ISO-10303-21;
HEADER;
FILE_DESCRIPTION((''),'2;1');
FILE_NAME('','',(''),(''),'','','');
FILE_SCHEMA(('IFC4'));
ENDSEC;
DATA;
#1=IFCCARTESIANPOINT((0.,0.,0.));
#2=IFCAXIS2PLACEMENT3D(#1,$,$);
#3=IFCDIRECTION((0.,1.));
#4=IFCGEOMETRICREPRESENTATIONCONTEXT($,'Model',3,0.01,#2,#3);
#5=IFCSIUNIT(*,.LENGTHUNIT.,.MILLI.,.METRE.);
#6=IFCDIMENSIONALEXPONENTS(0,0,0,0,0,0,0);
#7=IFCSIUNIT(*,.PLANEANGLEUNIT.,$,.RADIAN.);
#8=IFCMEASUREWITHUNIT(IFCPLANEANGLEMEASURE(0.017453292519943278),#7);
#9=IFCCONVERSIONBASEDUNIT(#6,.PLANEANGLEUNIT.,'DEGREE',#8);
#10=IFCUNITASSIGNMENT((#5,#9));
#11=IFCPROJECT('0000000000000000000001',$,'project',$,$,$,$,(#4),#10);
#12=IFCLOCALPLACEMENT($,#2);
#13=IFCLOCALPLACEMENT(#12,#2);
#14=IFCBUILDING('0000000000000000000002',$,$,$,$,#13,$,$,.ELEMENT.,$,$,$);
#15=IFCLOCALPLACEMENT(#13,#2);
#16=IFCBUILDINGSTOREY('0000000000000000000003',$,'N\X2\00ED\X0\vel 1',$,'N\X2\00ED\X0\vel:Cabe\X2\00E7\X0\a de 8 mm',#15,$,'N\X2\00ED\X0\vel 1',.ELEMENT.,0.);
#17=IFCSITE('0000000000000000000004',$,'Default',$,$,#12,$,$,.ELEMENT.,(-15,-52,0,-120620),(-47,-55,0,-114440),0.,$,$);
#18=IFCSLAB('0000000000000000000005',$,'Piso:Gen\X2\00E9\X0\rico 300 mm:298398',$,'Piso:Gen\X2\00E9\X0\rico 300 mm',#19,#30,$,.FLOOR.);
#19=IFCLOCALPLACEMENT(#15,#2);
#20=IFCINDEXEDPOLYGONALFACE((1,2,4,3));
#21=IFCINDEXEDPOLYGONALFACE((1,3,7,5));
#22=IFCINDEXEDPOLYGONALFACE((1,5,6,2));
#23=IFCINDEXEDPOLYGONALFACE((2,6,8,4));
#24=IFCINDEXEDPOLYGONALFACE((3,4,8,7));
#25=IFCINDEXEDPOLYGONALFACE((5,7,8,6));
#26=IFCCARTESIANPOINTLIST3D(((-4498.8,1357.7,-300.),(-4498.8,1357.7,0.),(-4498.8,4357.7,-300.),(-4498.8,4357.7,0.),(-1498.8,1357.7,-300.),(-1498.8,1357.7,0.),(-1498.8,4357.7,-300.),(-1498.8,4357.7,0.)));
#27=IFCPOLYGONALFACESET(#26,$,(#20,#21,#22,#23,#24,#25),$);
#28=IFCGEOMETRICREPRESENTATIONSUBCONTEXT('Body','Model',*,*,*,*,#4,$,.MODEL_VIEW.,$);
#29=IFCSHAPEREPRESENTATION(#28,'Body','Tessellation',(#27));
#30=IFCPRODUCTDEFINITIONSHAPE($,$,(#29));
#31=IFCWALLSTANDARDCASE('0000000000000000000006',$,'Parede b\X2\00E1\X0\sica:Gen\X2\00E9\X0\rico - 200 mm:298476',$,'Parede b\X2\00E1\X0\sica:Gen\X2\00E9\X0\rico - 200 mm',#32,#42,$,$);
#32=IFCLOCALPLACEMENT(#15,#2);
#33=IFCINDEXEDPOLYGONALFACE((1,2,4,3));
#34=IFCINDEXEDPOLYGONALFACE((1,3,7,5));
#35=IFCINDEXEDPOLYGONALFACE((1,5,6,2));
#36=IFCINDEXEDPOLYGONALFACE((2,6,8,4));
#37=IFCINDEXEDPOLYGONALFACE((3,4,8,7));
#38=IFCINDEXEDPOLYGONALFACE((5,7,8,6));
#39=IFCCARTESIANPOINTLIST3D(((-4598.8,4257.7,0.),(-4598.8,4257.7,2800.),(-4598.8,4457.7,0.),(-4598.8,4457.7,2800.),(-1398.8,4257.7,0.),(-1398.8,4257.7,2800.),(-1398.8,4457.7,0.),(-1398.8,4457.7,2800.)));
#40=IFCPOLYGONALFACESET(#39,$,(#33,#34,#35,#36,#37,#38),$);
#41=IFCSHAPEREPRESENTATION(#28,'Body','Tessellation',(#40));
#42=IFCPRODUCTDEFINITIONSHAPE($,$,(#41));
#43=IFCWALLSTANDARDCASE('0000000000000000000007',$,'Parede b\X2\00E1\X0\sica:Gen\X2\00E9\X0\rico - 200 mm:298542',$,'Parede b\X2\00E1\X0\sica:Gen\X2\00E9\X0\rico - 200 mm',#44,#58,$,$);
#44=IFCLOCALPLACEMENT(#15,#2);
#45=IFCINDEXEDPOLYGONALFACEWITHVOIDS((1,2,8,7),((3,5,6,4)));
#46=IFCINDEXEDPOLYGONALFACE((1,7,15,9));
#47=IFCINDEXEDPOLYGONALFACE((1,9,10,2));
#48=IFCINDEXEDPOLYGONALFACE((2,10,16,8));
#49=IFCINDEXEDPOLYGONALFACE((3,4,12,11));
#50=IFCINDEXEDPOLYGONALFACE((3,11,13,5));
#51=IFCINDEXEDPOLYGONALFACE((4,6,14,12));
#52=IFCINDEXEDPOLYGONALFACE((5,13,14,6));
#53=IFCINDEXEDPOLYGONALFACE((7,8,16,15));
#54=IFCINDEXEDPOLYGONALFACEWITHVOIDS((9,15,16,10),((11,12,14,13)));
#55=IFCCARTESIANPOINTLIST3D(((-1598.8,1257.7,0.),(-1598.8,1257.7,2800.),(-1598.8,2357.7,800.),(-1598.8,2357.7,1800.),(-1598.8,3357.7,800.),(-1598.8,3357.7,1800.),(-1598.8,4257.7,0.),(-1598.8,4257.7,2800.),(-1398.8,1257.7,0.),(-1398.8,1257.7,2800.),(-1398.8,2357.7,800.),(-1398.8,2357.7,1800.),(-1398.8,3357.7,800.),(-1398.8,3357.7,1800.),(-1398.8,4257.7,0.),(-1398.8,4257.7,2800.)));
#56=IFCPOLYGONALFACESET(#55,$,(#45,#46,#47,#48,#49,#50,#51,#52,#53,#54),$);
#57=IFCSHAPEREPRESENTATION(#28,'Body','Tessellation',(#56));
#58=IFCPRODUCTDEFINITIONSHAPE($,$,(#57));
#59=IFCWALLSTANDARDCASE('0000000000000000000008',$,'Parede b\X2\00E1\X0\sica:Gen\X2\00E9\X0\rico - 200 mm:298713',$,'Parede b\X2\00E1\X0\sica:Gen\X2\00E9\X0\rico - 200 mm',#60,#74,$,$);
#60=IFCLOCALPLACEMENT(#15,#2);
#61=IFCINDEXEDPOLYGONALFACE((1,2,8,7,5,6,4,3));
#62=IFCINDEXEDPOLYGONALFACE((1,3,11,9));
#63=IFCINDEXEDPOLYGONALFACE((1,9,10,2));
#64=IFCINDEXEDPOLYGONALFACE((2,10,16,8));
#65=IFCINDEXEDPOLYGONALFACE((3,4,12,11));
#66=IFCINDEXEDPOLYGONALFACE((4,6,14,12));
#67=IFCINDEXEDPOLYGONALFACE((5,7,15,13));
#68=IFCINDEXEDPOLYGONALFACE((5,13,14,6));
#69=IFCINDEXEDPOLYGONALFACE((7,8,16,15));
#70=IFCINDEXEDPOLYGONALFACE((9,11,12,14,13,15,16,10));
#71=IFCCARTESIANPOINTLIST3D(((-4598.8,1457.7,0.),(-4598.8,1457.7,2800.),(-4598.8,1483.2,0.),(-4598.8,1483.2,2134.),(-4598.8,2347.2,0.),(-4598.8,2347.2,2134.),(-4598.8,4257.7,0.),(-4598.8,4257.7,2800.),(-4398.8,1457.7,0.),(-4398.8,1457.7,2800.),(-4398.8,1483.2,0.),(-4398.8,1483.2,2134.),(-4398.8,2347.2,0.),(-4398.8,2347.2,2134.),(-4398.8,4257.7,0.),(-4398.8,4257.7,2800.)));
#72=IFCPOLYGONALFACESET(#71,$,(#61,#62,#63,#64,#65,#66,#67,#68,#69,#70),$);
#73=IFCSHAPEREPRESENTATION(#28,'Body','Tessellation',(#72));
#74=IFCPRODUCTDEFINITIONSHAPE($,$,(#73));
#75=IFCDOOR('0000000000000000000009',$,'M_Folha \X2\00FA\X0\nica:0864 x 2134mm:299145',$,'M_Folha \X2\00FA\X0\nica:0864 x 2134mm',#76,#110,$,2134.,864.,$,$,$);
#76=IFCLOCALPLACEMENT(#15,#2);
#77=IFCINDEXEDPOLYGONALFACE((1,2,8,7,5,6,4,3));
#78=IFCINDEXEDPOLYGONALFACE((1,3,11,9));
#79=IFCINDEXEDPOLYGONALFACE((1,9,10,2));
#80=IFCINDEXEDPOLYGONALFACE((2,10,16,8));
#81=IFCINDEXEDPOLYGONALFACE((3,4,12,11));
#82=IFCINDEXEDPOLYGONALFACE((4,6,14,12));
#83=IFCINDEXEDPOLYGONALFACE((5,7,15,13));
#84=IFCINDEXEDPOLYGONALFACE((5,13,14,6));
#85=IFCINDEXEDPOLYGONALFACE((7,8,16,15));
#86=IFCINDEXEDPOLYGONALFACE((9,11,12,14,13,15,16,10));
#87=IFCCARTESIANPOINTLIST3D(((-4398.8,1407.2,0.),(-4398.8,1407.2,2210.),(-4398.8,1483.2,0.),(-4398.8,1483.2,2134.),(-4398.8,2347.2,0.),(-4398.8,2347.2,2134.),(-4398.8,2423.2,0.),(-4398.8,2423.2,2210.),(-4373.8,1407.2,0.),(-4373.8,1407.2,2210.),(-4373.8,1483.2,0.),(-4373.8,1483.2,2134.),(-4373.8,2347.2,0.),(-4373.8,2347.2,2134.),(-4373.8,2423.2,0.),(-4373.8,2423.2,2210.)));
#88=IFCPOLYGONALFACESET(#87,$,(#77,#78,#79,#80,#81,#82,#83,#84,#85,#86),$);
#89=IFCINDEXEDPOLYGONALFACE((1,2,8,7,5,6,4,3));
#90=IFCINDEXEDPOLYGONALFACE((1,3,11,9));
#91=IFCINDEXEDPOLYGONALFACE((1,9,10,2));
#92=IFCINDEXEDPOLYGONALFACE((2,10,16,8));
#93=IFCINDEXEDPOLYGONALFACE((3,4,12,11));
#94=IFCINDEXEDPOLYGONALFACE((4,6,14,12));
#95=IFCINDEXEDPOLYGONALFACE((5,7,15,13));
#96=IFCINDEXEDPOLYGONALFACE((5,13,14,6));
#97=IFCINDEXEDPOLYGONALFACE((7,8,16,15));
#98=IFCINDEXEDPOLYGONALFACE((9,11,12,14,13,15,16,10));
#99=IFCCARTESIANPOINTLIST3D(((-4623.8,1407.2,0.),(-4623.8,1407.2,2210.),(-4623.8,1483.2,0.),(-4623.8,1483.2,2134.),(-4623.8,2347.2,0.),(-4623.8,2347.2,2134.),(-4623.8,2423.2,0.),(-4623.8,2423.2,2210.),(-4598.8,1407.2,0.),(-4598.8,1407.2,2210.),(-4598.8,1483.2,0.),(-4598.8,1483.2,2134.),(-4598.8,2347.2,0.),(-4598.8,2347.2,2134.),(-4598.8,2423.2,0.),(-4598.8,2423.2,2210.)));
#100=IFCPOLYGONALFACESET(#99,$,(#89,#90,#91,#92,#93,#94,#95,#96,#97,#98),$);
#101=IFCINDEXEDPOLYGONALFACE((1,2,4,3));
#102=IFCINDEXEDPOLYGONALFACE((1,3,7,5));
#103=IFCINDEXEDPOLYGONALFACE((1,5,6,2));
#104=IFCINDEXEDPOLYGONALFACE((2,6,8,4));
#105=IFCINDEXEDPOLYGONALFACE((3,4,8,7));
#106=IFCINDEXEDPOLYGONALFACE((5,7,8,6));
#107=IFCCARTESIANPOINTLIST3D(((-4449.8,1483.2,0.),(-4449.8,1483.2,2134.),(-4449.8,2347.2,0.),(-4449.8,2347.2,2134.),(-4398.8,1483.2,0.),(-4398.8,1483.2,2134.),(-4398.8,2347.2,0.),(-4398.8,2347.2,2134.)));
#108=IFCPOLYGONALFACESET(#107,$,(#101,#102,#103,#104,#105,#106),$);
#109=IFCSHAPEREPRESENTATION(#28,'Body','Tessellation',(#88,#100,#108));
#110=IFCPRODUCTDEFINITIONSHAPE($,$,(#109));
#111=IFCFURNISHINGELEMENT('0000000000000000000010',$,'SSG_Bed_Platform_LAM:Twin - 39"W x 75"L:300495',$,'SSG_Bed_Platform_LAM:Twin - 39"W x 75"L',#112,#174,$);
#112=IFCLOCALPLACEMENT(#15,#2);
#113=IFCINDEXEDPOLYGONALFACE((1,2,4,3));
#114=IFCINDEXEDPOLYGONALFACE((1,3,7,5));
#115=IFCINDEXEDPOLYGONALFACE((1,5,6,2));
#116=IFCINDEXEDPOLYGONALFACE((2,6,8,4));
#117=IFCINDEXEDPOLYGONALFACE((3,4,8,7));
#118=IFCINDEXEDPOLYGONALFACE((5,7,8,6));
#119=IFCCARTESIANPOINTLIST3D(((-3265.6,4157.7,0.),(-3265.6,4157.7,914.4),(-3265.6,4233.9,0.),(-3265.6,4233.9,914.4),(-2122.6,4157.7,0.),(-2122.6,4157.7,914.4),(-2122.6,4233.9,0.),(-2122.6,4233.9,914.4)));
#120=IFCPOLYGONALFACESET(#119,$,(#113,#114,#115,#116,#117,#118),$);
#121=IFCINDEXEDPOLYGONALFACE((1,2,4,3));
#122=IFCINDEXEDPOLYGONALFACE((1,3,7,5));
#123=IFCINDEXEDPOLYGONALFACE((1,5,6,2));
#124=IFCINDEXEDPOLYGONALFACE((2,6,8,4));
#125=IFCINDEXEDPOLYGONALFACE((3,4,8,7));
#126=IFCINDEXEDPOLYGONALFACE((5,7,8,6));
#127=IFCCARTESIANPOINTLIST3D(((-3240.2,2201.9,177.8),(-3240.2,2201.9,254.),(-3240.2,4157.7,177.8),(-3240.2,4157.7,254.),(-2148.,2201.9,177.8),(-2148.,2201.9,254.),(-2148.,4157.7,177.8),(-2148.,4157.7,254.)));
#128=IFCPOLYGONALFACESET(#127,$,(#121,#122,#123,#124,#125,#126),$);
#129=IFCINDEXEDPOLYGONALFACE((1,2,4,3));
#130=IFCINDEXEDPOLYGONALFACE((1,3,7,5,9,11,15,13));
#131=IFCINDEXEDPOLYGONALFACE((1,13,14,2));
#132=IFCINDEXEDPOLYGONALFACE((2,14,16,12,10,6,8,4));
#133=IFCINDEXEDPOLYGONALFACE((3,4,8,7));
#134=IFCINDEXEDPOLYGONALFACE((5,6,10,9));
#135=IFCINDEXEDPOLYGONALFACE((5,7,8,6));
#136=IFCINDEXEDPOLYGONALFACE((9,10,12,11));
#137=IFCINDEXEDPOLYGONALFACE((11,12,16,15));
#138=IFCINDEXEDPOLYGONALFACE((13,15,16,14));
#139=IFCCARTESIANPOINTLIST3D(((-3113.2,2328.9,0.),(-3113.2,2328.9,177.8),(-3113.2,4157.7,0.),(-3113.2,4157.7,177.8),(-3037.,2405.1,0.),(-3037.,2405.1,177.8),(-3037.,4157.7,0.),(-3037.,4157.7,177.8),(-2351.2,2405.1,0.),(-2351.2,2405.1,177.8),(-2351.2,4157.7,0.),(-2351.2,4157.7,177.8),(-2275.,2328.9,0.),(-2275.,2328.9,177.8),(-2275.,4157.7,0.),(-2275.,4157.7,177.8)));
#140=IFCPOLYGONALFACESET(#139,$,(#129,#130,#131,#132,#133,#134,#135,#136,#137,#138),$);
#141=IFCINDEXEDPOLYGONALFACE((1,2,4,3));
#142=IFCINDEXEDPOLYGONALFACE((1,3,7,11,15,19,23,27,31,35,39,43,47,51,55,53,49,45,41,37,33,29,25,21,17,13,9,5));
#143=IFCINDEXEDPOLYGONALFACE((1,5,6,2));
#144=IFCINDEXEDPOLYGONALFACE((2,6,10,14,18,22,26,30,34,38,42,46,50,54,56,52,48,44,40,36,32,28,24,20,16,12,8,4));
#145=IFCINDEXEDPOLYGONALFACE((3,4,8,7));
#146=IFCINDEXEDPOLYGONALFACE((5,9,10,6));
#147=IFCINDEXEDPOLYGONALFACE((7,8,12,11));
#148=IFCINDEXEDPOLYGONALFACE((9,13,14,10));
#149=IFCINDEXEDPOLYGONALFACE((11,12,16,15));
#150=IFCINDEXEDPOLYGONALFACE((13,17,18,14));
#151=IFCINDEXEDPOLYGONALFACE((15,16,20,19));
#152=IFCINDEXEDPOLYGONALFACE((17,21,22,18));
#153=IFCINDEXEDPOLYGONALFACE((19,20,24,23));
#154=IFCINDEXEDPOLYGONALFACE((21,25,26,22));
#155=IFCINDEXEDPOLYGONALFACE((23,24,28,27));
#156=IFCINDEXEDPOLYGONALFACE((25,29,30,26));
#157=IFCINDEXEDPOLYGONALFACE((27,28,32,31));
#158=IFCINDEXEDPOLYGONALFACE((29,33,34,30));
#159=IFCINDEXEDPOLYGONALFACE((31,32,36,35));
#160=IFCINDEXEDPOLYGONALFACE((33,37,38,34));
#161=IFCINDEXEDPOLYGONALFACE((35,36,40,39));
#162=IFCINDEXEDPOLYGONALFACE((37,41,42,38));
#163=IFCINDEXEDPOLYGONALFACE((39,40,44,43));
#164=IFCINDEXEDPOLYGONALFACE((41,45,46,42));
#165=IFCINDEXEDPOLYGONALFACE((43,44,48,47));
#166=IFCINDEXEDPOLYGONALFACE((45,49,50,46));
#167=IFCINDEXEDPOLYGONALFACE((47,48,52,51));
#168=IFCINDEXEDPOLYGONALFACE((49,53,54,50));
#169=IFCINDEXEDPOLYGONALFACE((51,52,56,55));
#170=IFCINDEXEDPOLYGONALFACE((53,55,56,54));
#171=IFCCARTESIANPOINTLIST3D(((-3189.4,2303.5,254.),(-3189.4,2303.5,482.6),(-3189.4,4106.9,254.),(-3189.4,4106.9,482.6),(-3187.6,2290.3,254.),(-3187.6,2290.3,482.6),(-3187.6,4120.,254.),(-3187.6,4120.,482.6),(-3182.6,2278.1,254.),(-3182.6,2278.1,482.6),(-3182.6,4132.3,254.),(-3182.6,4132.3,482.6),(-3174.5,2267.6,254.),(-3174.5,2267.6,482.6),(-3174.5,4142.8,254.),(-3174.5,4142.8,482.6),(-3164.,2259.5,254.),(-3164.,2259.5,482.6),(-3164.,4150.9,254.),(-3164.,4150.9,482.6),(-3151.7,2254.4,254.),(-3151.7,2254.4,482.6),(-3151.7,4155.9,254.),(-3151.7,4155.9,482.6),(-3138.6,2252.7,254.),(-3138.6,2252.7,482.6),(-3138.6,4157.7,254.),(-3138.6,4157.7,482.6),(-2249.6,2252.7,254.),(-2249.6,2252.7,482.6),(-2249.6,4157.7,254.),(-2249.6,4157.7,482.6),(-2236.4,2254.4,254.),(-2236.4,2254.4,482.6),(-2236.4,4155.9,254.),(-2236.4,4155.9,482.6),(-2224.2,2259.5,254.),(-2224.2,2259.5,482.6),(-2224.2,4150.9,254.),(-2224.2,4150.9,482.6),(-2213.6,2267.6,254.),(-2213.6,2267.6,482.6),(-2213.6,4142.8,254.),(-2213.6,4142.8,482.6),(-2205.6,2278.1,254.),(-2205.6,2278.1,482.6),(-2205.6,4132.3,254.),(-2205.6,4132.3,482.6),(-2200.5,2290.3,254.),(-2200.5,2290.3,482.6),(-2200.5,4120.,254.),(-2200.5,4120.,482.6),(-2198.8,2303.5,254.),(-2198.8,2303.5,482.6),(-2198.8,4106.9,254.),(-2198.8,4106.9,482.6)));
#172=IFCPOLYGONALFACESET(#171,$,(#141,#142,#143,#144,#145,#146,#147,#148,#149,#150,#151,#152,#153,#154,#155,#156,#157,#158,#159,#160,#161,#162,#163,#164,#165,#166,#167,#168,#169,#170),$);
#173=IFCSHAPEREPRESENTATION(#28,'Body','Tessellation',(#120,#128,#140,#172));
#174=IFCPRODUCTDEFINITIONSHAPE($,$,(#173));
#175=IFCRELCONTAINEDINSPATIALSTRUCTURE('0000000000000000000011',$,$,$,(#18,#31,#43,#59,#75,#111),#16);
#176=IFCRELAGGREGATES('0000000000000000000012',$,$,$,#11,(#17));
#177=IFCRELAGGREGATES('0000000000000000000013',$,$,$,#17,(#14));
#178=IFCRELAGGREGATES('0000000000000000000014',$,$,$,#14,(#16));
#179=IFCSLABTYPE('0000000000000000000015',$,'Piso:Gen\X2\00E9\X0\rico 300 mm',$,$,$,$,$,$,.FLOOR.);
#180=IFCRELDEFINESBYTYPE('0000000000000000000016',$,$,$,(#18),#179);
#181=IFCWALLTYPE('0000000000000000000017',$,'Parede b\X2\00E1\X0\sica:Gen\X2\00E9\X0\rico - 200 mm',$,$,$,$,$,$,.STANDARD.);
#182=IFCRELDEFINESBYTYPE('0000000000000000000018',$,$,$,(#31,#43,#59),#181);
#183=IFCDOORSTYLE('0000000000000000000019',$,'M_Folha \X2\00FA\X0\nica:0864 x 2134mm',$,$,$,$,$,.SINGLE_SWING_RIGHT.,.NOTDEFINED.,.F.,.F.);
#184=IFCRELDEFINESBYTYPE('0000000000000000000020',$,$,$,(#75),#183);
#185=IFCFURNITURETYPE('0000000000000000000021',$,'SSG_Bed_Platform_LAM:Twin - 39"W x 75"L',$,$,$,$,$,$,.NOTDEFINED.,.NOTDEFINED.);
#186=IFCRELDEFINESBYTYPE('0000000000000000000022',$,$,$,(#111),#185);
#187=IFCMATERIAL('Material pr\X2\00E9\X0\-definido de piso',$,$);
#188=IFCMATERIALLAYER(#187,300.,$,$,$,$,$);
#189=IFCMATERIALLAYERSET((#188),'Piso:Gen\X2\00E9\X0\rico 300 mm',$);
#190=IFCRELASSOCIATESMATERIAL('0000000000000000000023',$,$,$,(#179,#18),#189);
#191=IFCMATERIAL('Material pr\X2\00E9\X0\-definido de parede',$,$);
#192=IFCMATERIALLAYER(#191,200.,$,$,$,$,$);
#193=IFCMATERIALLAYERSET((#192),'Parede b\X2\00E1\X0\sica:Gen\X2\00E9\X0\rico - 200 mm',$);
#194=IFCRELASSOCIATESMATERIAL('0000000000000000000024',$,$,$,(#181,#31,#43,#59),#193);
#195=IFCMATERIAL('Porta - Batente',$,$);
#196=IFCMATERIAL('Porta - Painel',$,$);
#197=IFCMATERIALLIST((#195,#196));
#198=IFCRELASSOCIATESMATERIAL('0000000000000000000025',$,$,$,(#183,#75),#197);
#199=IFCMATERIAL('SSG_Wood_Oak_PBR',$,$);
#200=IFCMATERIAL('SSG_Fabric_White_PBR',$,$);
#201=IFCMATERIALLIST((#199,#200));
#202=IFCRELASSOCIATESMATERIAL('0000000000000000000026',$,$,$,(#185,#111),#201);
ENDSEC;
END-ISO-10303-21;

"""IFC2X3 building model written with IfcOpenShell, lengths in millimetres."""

from ifc_helpers import new_model, entity, si_unit, converted_unit, direction, frame, frame_2d, origin, origin_2d_with_axis, place, context, subcontext, project, spatial, polyline, circle_curve, parameter, trimmed, segment, composite_curve, rectangle, outline, extrude, source, transform, mapped, material, material_list, layer, layer_set, layer_usage, type_object, type_shapes, element, fill, save


model = new_model("IFC2X3")

# Units and contexts
model_context = context("Model", 3, precision=0.01, world=origin(), true_north=direction((0.0, 1.0)))
body_context = subcontext(model_context, "Body", "Model", "MODEL_VIEW")
ifc_project = project(units=[si_unit("LENGTHUNIT", "METRE", prefix="MILLI"), converted_unit("PLANEANGLEUNIT", "DEGREE", entity("IfcPlaneAngleMeasure", 0.017453292519943278), si_unit("PLANEANGLEUNIT", "RADIAN"), dimensions=[0, 0, 0, 0, 0, 0, 0])], contexts=[model_context])

# Site, building, storey
site_placement = place(None, origin())
site = spatial("IfcSite", under=ifc_project, at=site_placement, Name="Default", CompositionType="ELEMENT", RefLatitude=(-15, -52, 0, -120620), RefLongitude=(-47, -55, 0, -114440), RefElevation=0.0)
building_placement = place(site_placement, origin())
building = spatial("IfcBuilding", under=site, at=building_placement, CompositionType="ELEMENT")
storey_placement = place(building_placement, origin())
storey = spatial("IfcBuildingStorey", under=building, at=storey_placement, Name="Nível 1", ObjectType="Nível:Cabeça de 8 mm", LongName="Nível 1", CompositionType="ELEMENT", Elevation=0.0)

# Slab
ifc_material_1 = material(Name="Material pré-definido de piso")
ifc_layer_1 = layer(ifc_material_1, 300.0)
ifc_layer_set_1 = layer_set([ifc_layer_1], Name="Piso:Genérico 300 mm")
ifc_layer_usage_1 = layer_usage(ifc_layer_set_1, "AXIS3", "POSITIVE", 0.0)
slab_type = type_object("IfcSlabType", Name="Piso:Genérico 300 mm", PredefinedType="FLOOR", material=ifc_layer_set_1)
slab_placement = place(storey_placement, origin())
element("IfcSlab", 1, at=slab_placement, inside=storey, type_object=slab_type, material=ifc_layer_usage_1, Name="Piso:Genérico 300 mm:298398", ObjectType="Piso:Genérico 300 mm", PredefinedType="FLOOR", context=body_context, shape_type="SweptSolid", body=[
    extrude(rectangle(XDim=3000.0, YDim=3000.0, at=origin_2d_with_axis()), frame((-2998.8, 2857.7, 0.0), z_axis=(0.0, 0.0, -1.0), x_axis=(0.0, 1.0, 0.0)), (0.0, 0.0, 1.0), 300.0),
])

# Wall
ifc_material_2 = material(Name="Material pré-definido de parede")
ifc_layer_2 = layer(ifc_material_2, 200.0)
ifc_layer_set_2 = layer_set([ifc_layer_2], Name="Parede básica:Genérico - 200 mm")
ifc_layer_usage_2 = layer_usage(ifc_layer_set_2, "AXIS2", "NEGATIVE", 100.0)
wall_type = type_object("IfcWallType", Name="Parede básica:Genérico - 200 mm", PredefinedType="STANDARD", material=ifc_layer_set_2)
wall_1_placement = place(storey_placement, frame((-4598.8, 4357.7, 0.0)))
element("IfcWallStandardCase", 2, at=wall_1_placement, inside=storey, type_object=wall_type, material=ifc_layer_usage_2, Name="Parede básica:Genérico - 200 mm:298476", ObjectType="Parede básica:Genérico - 200 mm", context=body_context, shape_type="SweptSolid", body=[
    extrude(rectangle(XDim=3200.0, YDim=200.0, at=frame_2d((1600.0, 0.0), x_axis=(-1.0, 0.0))), origin(), (0.0, 0.0, 1.0), 2800.0),
])

# Wall, opening
wall_2_placement = place(storey_placement, frame((-1498.8, 4257.7, 0.0), z_axis=(0.0, 0.0, 1.0), x_axis=(0.0, -1.0, 0.0)))
wall_2 = element("IfcWallStandardCase", 3, at=wall_2_placement, inside=storey, type_object=wall_type, material=ifc_layer_usage_2, Name="Parede básica:Genérico - 200 mm:298542", ObjectType="Parede básica:Genérico - 200 mm", context=body_context, shape_type="SweptSolid", body=[
    extrude(rectangle(XDim=3000.0, YDim=200.0, at=frame_2d((1500.0, 0.0), x_axis=(-1.0, 0.0))), origin(), (0.0, 0.0, 1.0), 2800.0),
])
opening_1_placement = place(wall_2_placement, frame((1900.0, 100.0, 800.0)))
element("IfcOpeningElement", 4, at=opening_1_placement, cuts=wall_2, ObjectType="Opening", context=body_context, shape_type="SweptSolid", body=[
    extrude(rectangle(XDim=1000.0, YDim=1000.0, at=frame_2d((500.0, 500.0), x_axis=(1.0, 0.0))), frame((0.0, 0.0, 0.0), z_axis=(0.0, -1.0, 0.0), x_axis=(0.0, 0.0, 1.0)), (0.0, 0.0, 1.0), 200.0),
])

# Wall, opening, door
wall_3_placement = place(storey_placement, frame((-4498.8, 1457.7, 0.0), z_axis=(0.0, 0.0, 1.0), x_axis=(0.0, 1.0, 0.0)))
wall_3 = element("IfcWallStandardCase", 5, at=wall_3_placement, inside=storey, type_object=wall_type, material=ifc_layer_usage_2, Name="Parede básica:Genérico - 200 mm:298713", ObjectType="Parede básica:Genérico - 200 mm", context=body_context, shape_type="SweptSolid", body=[
    extrude(rectangle(XDim=2800.0, YDim=200.0, at=frame_2d((1400.0, 0.0), x_axis=(-1.0, 0.0))), origin(), (0.0, 0.0, 1.0), 2800.0),
])
opening_2_placement = place(wall_3_placement, frame((889.5, 100.0, 0.0)))
opening_2 = element("IfcOpeningElement", 6, at=opening_2_placement, cuts=wall_3, ObjectType="Opening", context=body_context, shape_type="SweptSolid", body=[
    extrude(rectangle(XDim=864.0, YDim=2134.0, at=frame_2d((1067.0, 432.0), x_axis=(0.0, 1.0))), frame((0.0, 0.0, 0.0), z_axis=(0.0, -1.0, 0.0), x_axis=(0.0, 0.0, 1.0)), (0.0, 0.0, 1.0), 200.0),
])
ifc_material_3 = material(Name="Porta - Batente")
ifc_material_4 = material(Name="Porta - Painel")
ifc_material_list_1 = material_list([ifc_material_3, ifc_material_4])
door_style = type_object("IfcDoorStyle", Name="M_Folha única:0864 x 2134mm", ConstructionType="NOTDEFINED", OperationType="SINGLE_SWING_RIGHT", ParameterTakesPrecedence=False, Sizeable=False, material=ifc_material_list_1)
shared_shape_1 = source(origin(), body_context, "Body", "SweptSolid", [
    extrude(outline(polyline([(-508.0, -1124.0), (508.0, -1124.0), (508.0, 1086.0), (432.0, 1086.0), (432.0, -1048.0), (-432.0, -1048.0), (-432.0, 1086.0), (-508.0, 1086.0), (-508.0, -1124.0)])), frame((432.0, 200.0, 1086.0), z_axis=(0.0, 1.0, 0.0), x_axis=(1.0, 0.0, 0.0)), (0.0, 0.0, 1.0), 25.0),
    extrude(outline(polyline([(-1124.0, -508.0), (1086.0, -508.0), (1086.0, -432.0), (-1048.0, -432.0), (-1048.0, 432.0), (1086.0, 432.0), (1086.0, 508.0), (-1124.0, 508.0), (-1124.0, -508.0)])), frame((432.0, -25.0, 1086.0), z_axis=(0.0, 1.0, 0.0), x_axis=(0.0, 0.0, -1.0)), (0.0, 0.0, 1.0), 25.0),
    extrude(rectangle(XDim=51.0, YDim=864.0, at=frame_2d((0.0, 0.0), x_axis=(1.0, 0.0))), frame((432.0, 174.5, 0.0), z_axis=(0.0, 0.0, 1.0), x_axis=(0.0, 1.0, 0.0)), (0.0, 0.0, 1.0), 2134.0),
])
type_shapes(door_style, [shared_shape_1])
door_placement = place(opening_2_placement, frame((0.0, 0.0, 0.0), z_axis=(0.0, 0.0, 1.0), x_axis=(-1.0, 0.0, 0.0)))
door = element("IfcDoor", 7, at=door_placement, inside=storey, type_object=door_style, material=ifc_material_list_1, Name="M_Folha única:0864 x 2134mm:299145", ObjectType="M_Folha única:0864 x 2134mm", OverallHeight=2134.0, OverallWidth=864.0, context=body_context, shape_type="MappedRepresentation", body=[
    mapped(shared_shape_1, transform((0.0, 0.0, 0.0), scale=1.0)),
])
fill(opening_2, door)

# Furnishing element
ifc_material_5 = material(Name="SSG_Wood_Oak_PBR")
ifc_material_6 = material(Name="SSG_Fabric_White_PBR")
ifc_material_list_2 = material_list([ifc_material_5, ifc_material_6])
furniture_type = type_object("IfcFurnitureType", Name="SSG_Bed_Platform_LAM:Twin - 39\"W x 75\"L", AssemblyPlace="NOTDEFINED", material=ifc_material_list_2)
shared_shape_2 = source(origin(), body_context, "Body", "SweptSolid", [
    extrude(rectangle(XDim=1143.0, YDim=76.2, at=frame_2d((0.0, 0.0), x_axis=(1.0, 0.0))), frame((0.0, 990.6, 0.0), z_axis=(0.0, 0.0, 1.0), x_axis=(-1.0, 0.0, 0.0)), (0.0, 0.0, 1.0), 914.4),
    extrude(rectangle(XDim=1955.8, YDim=1092.2, at=origin_2d_with_axis()), frame((0.0, -25.4, 177.8), z_axis=(0.0, 0.0, 1.0), x_axis=(0.0, -1.0, 0.0)), (0.0, 0.0, 1.0), 76.2),
    extrude(outline(polyline([(-895.4, -419.1), (933.5, -419.1), (933.5, 419.1), (-895.4, 419.1), (-895.4, 342.9), (857.3, 342.9), (857.3, -342.9), (-895.4, -342.9), (-895.4, -419.1)])), frame((0.0, 57.1, 0.0), z_axis=(0.0, 0.0, 1.0), x_axis=(0.0, -1.0, 0.0)), (0.0, 0.0, 1.0), 177.8),
    extrude(outline(composite_curve([segment(trimmed(circle_curve(frame_2d((-444.5, -901.7), x_axis=(1.0, 0.0)), 50.8), [parameter(180.0)], [parameter(270.0)], True, "PARAMETER"), True, "CONTINUOUS"), segment(polyline([(-444.5, -952.5), (444.5, -952.5)]), True, "CONTINUOUS"), segment(trimmed(circle_curve(frame_2d((444.5, -901.7), x_axis=(1.0, 0.0)), 50.8), [parameter(270.0)], [parameter(360.0)], True, "PARAMETER"), True, "CONTINUOUS"), segment(polyline([(495.3, -901.7), (495.3, 901.7)]), True, "CONTINUOUS"), segment(trimmed(circle_curve(frame_2d((444.5, 901.7), x_axis=(1.0, 0.0)), 50.8), [parameter(360.0)], [parameter(90.0)], True, "PARAMETER"), True, "CONTINUOUS"), segment(polyline([(444.5, 952.5), (-444.5, 952.5)]), True, "CONTINUOUS"), segment(trimmed(circle_curve(frame_2d((-444.5, 901.7), x_axis=(1.0, 0.0)), 50.8), [parameter(90.0)], [parameter(180.0)], True, "PARAMETER"), True, "CONTINUOUS"), segment(polyline([(-495.3, 901.7), (-495.3, -901.7)]), True, "CONTINUOUS")], self_intersect=False)), frame((0.0, 0.0, 254.0)), (0.0, 0.0, 1.0), 228.6),
])
type_shapes(furniture_type, [shared_shape_2])
furnishing_placement = place(storey_placement, frame((-2694.1, 3205.2, 0.0)))
element("IfcFurnishingElement", 8, at=furnishing_placement, inside=storey, type_object=furniture_type, material=ifc_material_list_2, Name="SSG_Bed_Platform_LAM:Twin - 39\"W x 75\"L:300495", ObjectType="SSG_Bed_Platform_LAM:Twin - 39\"W x 75\"L", context=body_context, shape_type="MappedRepresentation", body=[
    mapped(shared_shape_2, transform((0.0, 0.0, 0.0), scale=1.0)),
])

save(model, "model.ifc")
